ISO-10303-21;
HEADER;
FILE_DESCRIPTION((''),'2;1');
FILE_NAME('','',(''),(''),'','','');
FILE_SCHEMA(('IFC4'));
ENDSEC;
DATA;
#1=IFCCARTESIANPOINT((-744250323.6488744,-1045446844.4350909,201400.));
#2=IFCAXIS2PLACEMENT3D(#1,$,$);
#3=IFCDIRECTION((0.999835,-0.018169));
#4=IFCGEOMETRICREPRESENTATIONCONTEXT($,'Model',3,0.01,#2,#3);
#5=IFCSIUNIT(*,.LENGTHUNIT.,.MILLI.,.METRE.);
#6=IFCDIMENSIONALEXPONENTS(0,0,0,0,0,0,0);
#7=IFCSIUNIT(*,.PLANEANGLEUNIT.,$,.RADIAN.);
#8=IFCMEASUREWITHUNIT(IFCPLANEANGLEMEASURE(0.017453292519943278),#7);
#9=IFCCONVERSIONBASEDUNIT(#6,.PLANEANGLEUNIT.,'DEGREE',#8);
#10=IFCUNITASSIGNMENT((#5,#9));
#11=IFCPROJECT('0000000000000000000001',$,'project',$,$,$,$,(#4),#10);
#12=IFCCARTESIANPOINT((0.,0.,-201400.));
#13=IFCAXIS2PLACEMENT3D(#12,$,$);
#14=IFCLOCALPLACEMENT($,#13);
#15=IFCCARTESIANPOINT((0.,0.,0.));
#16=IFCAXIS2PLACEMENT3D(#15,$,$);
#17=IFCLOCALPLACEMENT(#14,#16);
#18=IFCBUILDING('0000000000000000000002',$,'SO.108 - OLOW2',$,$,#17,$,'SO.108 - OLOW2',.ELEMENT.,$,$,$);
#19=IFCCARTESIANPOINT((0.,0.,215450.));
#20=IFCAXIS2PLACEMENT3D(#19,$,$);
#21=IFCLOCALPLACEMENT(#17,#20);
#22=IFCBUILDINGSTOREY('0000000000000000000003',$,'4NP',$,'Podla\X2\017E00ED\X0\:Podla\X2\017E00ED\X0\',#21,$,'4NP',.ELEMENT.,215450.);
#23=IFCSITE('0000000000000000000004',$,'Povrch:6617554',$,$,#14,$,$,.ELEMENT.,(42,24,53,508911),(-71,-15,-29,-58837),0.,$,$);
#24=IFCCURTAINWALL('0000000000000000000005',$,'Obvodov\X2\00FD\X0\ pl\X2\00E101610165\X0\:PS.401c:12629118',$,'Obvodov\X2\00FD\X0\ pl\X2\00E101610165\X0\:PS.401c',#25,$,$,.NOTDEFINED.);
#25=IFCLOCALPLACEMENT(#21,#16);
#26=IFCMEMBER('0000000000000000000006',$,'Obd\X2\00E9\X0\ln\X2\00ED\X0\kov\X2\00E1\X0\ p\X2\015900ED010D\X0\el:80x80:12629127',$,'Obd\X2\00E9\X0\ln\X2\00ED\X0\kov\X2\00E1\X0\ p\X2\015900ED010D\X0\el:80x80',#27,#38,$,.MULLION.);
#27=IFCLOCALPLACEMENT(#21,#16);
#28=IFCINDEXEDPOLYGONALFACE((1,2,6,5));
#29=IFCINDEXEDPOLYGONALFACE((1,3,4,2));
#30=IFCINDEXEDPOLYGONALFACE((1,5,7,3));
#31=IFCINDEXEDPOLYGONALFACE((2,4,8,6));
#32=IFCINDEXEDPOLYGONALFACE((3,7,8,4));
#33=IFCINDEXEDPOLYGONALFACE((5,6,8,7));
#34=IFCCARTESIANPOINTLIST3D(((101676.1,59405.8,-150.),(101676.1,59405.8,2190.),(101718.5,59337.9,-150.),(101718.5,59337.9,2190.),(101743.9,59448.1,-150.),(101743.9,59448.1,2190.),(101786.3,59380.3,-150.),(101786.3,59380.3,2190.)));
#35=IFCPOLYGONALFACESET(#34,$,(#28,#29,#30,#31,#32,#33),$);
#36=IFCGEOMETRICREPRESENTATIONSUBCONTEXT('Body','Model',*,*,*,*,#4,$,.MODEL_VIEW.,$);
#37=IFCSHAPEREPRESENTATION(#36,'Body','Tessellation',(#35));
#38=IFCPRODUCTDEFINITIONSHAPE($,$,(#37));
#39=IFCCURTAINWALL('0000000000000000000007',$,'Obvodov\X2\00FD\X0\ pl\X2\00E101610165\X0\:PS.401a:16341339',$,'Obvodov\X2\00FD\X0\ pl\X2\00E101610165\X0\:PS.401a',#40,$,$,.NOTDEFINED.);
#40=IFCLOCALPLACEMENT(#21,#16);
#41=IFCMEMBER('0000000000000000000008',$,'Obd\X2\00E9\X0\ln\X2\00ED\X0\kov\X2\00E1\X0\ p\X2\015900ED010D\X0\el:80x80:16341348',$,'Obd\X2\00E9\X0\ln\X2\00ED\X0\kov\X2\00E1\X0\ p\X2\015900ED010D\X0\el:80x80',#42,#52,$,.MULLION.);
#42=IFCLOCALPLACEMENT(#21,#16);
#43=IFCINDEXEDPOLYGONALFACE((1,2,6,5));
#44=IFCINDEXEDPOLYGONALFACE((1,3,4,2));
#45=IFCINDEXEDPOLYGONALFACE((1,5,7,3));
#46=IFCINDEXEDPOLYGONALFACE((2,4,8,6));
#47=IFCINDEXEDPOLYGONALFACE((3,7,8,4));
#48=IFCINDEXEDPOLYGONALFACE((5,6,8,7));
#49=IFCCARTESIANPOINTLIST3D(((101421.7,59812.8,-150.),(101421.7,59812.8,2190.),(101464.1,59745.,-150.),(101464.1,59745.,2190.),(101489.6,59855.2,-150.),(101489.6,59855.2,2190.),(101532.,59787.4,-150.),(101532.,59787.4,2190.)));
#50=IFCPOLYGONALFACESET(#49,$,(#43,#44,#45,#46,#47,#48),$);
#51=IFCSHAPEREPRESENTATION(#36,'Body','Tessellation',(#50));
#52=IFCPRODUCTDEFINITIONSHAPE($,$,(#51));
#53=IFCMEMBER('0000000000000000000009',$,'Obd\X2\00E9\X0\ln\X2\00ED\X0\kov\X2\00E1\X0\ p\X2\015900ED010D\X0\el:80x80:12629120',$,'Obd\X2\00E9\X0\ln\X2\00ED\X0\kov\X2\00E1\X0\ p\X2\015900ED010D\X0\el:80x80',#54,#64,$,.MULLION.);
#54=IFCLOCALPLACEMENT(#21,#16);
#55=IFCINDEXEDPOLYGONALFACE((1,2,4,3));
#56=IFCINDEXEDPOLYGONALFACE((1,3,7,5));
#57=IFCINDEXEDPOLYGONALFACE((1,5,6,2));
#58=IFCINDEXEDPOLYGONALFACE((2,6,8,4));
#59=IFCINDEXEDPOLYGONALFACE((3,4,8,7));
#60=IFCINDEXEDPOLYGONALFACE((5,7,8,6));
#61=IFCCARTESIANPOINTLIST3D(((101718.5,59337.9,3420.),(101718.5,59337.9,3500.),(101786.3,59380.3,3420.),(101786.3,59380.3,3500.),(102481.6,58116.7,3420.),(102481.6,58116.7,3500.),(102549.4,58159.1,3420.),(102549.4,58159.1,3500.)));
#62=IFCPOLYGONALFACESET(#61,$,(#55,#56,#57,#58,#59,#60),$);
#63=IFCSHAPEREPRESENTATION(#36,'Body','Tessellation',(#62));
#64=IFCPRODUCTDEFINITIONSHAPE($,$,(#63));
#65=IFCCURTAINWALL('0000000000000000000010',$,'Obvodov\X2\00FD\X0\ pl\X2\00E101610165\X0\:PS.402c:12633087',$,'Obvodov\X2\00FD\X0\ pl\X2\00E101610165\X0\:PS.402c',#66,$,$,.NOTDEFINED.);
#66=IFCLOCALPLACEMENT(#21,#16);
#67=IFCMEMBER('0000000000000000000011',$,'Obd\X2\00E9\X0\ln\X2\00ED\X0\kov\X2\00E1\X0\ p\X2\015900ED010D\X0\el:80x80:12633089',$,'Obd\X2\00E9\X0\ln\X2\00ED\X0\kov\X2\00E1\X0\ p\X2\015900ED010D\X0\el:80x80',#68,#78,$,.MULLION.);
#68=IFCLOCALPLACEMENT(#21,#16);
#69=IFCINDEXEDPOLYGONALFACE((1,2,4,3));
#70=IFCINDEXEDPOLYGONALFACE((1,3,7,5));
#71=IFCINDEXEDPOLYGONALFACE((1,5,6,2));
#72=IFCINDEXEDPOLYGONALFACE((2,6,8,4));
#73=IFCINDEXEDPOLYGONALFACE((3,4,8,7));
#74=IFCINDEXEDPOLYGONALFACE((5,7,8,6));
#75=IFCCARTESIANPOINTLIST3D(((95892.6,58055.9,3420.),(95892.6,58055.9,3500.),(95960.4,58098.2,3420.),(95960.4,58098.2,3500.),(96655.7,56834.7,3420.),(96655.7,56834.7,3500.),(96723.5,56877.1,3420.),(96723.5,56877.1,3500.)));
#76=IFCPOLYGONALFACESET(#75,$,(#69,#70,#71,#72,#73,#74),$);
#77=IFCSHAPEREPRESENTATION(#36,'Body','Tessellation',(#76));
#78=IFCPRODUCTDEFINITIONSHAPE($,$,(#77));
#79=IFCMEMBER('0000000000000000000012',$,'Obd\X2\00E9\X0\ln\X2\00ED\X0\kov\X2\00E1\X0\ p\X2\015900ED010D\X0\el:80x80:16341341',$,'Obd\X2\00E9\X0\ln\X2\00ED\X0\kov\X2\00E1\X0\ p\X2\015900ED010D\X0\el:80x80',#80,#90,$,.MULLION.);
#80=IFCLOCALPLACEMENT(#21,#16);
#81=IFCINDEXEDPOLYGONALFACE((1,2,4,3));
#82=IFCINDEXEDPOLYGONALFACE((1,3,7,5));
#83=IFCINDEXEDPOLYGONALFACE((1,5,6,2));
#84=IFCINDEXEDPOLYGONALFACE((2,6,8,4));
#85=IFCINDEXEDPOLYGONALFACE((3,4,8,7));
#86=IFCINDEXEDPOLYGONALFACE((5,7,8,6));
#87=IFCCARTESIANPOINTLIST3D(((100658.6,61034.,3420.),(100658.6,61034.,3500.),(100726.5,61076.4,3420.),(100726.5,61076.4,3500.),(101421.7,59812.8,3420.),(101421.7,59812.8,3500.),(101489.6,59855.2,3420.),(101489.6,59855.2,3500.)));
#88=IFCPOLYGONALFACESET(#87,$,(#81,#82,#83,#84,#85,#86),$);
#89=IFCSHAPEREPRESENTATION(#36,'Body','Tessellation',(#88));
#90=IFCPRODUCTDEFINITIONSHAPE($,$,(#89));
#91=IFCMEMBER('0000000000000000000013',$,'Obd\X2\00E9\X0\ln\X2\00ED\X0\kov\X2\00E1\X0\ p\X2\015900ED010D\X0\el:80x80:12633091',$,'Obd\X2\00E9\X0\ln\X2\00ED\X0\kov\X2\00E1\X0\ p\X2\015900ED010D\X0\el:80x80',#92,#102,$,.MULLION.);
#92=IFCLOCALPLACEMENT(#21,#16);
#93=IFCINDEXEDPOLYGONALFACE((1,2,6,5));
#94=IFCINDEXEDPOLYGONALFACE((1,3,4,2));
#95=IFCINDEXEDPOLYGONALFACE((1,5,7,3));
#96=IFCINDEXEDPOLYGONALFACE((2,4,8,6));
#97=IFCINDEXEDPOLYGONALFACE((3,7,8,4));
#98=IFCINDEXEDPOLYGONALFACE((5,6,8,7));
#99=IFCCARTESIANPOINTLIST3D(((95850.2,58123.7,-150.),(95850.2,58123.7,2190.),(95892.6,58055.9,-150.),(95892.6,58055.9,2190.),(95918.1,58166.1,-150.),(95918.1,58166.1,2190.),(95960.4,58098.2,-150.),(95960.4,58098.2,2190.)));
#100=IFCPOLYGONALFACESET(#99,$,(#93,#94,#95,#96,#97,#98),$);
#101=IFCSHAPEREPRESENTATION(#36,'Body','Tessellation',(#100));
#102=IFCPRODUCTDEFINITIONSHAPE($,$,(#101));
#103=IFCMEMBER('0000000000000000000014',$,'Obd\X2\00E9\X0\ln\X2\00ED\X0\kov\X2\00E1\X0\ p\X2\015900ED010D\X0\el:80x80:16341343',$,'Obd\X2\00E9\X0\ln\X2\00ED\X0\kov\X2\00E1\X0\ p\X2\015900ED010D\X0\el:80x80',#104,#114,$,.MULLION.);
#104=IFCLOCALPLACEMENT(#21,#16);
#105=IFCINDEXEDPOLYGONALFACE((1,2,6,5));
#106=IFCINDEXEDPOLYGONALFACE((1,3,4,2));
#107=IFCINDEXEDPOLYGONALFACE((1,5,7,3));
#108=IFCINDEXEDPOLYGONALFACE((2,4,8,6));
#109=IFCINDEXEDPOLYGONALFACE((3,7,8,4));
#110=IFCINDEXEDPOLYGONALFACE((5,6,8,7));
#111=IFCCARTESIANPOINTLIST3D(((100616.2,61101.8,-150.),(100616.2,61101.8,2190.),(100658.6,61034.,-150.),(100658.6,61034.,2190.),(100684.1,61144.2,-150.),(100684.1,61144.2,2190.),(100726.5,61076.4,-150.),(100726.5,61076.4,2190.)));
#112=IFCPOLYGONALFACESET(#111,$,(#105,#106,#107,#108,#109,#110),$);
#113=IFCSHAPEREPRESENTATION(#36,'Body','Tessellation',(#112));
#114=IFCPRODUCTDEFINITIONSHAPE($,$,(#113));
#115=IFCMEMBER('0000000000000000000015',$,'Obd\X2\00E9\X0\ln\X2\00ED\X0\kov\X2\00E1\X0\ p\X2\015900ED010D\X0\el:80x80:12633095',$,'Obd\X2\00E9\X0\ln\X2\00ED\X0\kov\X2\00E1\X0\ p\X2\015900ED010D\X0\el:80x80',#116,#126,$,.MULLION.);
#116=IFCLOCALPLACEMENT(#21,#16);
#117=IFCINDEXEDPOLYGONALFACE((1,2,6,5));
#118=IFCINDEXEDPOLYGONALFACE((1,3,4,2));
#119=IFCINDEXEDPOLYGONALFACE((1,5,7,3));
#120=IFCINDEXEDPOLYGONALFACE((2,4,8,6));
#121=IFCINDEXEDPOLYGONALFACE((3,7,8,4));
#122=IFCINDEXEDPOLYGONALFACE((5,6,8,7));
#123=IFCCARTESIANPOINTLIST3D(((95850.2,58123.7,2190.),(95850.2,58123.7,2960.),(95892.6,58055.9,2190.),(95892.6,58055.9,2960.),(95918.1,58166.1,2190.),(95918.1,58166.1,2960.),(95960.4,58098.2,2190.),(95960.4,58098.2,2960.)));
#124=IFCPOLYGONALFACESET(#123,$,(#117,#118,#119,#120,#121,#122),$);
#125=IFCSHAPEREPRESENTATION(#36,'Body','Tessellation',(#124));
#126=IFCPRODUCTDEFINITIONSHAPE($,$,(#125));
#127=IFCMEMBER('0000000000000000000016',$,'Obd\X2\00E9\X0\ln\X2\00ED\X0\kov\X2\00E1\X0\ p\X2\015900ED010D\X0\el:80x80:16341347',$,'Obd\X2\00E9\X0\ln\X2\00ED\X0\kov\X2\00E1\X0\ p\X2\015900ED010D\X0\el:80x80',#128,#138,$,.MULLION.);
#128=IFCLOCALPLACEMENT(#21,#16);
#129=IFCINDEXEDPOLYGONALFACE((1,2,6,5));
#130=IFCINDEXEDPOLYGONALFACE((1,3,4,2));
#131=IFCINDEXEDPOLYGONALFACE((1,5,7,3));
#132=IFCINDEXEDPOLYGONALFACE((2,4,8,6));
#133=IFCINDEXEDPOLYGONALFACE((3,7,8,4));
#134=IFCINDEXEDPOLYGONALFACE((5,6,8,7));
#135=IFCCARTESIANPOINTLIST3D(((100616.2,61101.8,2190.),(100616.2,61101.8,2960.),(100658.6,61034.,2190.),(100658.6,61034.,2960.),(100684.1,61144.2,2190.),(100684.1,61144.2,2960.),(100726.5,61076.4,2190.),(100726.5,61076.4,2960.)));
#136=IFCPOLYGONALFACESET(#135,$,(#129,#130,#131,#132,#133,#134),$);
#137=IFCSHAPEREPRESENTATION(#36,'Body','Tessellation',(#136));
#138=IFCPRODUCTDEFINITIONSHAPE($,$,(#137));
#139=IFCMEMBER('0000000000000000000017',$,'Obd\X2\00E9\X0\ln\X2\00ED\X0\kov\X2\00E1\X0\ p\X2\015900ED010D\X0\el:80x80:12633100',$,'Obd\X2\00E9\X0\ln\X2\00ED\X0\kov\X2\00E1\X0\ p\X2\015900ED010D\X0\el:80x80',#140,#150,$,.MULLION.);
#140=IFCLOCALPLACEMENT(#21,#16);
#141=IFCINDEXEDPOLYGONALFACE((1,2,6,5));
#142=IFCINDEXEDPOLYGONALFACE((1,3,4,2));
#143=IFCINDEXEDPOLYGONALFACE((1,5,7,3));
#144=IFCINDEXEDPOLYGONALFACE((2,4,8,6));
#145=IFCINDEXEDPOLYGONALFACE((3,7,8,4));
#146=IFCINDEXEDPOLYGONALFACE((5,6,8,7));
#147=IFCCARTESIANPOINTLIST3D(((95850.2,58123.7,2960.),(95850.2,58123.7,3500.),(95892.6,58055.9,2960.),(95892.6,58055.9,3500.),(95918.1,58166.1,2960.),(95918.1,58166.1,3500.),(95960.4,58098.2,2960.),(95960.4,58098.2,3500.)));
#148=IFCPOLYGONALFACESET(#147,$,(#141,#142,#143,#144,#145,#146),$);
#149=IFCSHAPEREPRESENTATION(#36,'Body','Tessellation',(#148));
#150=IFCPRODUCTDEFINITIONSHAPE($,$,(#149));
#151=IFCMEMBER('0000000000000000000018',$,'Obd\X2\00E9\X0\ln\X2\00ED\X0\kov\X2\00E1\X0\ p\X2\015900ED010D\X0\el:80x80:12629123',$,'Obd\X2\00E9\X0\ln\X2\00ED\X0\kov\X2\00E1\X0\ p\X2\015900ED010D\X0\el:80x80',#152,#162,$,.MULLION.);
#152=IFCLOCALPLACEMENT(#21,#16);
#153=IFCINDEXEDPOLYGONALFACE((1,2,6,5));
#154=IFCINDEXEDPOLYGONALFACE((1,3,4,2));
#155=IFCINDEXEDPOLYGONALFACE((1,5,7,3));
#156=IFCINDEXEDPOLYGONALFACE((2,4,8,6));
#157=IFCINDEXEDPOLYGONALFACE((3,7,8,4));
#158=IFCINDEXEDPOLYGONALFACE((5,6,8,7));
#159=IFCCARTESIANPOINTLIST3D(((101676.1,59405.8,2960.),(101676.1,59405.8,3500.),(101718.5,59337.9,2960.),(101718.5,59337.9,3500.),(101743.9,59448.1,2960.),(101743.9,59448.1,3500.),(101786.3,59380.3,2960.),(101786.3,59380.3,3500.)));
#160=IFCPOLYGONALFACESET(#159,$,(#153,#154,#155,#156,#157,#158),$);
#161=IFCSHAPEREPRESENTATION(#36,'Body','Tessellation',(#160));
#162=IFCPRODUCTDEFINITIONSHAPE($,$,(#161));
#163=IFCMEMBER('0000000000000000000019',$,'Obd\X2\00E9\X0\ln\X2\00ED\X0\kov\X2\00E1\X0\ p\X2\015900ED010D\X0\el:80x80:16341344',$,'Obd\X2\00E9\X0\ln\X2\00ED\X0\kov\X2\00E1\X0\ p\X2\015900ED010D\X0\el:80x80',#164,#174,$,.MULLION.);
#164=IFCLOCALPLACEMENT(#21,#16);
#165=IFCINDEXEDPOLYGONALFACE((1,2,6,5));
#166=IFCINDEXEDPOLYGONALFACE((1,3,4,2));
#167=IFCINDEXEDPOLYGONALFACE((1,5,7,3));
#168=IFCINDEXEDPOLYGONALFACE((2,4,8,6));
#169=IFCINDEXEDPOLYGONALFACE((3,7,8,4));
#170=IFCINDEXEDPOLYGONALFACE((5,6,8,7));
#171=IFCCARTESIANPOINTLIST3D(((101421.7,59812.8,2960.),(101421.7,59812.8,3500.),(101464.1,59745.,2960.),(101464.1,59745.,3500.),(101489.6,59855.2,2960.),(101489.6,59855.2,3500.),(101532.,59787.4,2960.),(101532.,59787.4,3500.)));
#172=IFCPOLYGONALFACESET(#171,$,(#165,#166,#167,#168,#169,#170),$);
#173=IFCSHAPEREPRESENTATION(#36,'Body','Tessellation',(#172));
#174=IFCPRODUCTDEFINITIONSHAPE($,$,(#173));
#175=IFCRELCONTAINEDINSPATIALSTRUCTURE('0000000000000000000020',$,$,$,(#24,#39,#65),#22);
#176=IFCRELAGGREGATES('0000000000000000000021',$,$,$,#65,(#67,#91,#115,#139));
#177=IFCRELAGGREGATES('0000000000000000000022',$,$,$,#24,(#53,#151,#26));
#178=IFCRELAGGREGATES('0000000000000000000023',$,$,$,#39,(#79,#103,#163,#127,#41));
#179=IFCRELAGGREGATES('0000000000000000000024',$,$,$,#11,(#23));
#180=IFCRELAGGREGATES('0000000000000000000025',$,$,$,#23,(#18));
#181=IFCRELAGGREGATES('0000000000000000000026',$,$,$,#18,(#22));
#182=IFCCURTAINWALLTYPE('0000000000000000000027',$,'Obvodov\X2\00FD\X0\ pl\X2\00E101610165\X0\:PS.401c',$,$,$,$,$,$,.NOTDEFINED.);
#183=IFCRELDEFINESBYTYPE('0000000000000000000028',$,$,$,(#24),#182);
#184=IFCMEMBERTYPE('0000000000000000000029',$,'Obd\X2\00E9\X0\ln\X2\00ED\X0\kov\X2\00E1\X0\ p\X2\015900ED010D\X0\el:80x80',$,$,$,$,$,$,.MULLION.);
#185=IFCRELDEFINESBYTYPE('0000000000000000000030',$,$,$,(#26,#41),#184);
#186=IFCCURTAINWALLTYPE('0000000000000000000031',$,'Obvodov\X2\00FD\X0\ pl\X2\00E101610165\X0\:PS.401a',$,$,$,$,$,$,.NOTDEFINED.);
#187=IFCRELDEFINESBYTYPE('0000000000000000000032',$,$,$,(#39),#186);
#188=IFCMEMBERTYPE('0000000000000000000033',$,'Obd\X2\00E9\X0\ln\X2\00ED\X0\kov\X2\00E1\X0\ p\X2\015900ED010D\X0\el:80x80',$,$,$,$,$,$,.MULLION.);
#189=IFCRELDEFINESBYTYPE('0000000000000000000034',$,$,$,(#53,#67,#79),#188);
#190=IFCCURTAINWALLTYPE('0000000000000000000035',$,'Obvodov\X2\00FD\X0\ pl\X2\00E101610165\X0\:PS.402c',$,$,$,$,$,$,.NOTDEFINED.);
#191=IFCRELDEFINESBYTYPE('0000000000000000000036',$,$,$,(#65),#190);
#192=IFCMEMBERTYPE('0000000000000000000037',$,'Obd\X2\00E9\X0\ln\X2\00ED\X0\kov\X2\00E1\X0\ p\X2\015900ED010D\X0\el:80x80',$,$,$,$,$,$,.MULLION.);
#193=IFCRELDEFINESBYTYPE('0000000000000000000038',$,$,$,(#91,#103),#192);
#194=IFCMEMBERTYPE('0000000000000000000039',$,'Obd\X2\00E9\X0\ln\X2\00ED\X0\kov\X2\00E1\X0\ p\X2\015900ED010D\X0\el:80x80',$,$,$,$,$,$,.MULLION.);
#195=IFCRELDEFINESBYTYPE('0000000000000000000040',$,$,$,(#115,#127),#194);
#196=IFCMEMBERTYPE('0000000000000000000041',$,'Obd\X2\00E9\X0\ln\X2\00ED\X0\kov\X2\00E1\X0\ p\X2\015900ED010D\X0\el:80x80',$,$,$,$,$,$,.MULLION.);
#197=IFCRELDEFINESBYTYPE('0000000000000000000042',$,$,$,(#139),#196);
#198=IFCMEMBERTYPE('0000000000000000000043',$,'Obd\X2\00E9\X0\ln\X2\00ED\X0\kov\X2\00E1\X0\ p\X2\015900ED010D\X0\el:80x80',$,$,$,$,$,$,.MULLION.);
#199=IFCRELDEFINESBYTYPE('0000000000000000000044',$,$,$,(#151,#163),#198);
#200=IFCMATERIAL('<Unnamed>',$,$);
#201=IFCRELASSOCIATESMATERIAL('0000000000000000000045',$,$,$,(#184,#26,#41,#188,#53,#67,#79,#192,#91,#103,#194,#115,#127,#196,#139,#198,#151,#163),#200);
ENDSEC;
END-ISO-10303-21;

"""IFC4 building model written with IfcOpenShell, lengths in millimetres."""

from ifc_helpers import new_model, entity, si_unit, converted_unit, direction, frame, origin, place, context, subcontext, project, spatial, indexed_curve, outline, extrude, source, transform, mapped, material, type_object, type_shapes, element, aggregate, save


model = new_model("IFC4")

# Units and contexts
model_context = context("Model", 3, precision=0.01, world=frame((-744250323.6488744, -1045446844.4350909, 201400.0)), true_north=direction((0.999835, -0.018169)))
body_context = subcontext(model_context, "Body", "Model", "MODEL_VIEW")
ifc_project = project(units=[si_unit("LENGTHUNIT", "METRE", prefix="MILLI"), converted_unit("PLANEANGLEUNIT", "DEGREE", entity("IfcPlaneAngleMeasure", 0.017453292519943278), si_unit("PLANEANGLEUNIT", "RADIAN"), dimensions=[0, 0, 0, 0, 0, 0, 0])], contexts=[model_context])

# Site, building, storey
site_placement = place(None, frame((0.0, 0.0, -201400.0)))
site = spatial("IfcSite", under=ifc_project, at=site_placement, Name="Povrch:6617554", CompositionType="ELEMENT", RefLatitude=(42, 24, 53, 508911), RefLongitude=(-71, -15, -29, -58837), RefElevation=0.0)
building_placement = place(site_placement, origin())
building = spatial("IfcBuilding", under=site, at=building_placement, Name="SO.108 - OLOW2", LongName="SO.108 - OLOW2", CompositionType="ELEMENT")
storey_placement = place(building_placement, frame((0.0, 0.0, 215450.0)))
storey = spatial("IfcBuildingStorey", under=building, at=storey_placement, Name="4NP", ObjectType="Podlaží:Podlaží", LongName="4NP", CompositionType="ELEMENT", Elevation=215450.0)

# Curtain walls, members
curtain_wall_type_1 = type_object("IfcCurtainWallType", Name="Obvodový plášť:PS.401c", PredefinedType="NOTDEFINED")
curtain_wall_1_placement = place(storey_placement, frame((0.0, 0.0, -215450.0)))
curtain_wall_1 = element("IfcCurtainWall", 1, at=curtain_wall_1_placement, inside=storey, type_object=curtain_wall_type_1, Name="Obvodový plášť:PS.401c:12629118", ObjectType="Obvodový plášť:PS.401c", PredefinedType="NOTDEFINED")
ifc_material_1 = material(Name="<Unnamed>")
member_type_1 = type_object("IfcMemberType", Name="Obdélníková příčel:80x80", PredefinedType="MULLION", material=ifc_material_1)
shared_shape_1 = source(origin(), body_context, "Body", "SweptSolid", [
    extrude(outline(indexed_curve([(-40.0, -40.0), (40.0, -40.0), (40.0, 40.0), (-40.0, 40.0), (-40.0, -40.0)], self_intersect=False)), frame((-40.0, 0.0, -2340.0), z_axis=(0.0, 0.0, 1.0), x_axis=(-1.0, 0.0, 0.0)), (0.0, 0.0, 1.0), 2340.0),
])
type_shapes(member_type_1, [shared_shape_1])
member_1_placement = place(curtain_wall_1_placement, frame((101710.0, 59426.9, 217640.0), z_axis=(0.0, 0.0, 1.0), x_axis=(-0.529919, 0.848048, 0.0)))
member_1 = element("IfcMember", 2, at=member_1_placement, type_object=member_type_1, material=ifc_material_1, Name="Obdélníková příčel:80x80:12629127", ObjectType="Obdélníková příčel:80x80", PredefinedType="MULLION", context=body_context, shape_type="MappedRepresentation", body=[
    mapped(shared_shape_1, transform((0.0, 0.0, 0.0), scale=1.0)),
])
curtain_wall_type_2 = type_object("IfcCurtainWallType", Name="Obvodový plášť:PS.401a", PredefinedType="NOTDEFINED")
curtain_wall_2_placement = place(storey_placement, frame((0.0, 0.0, -215450.0)))
curtain_wall_2 = element("IfcCurtainWall", 3, at=curtain_wall_2_placement, inside=storey, type_object=curtain_wall_type_2, Name="Obvodový plášť:PS.401a:16341339", ObjectType="Obvodový plášť:PS.401a", PredefinedType="NOTDEFINED")
member_2_placement = place(curtain_wall_2_placement, frame((101498.0, 59766.2, 217640.0), z_axis=(0.0, 0.0, 1.0), x_axis=(0.529919, -0.848048, 0.0)))
member_2 = element("IfcMember", 4, at=member_2_placement, type_object=member_type_1, material=ifc_material_1, Name="Obdélníková příčel:80x80:16341348", ObjectType="Obdélníková příčel:80x80", PredefinedType="MULLION", context=body_context, shape_type="MappedRepresentation", body=[
    mapped(shared_shape_1, transform((0.0, 0.0, 0.0), scale=1.0)),
])

# Member
member_type_2 = type_object("IfcMemberType", Name="Obdélníková příčel:80x80", PredefinedType="MULLION", material=ifc_material_1)
shared_shape_2 = source(origin(), body_context, "Body", "SweptSolid", [
    extrude(outline(indexed_curve([(-40.0, -40.0), (40.0, -40.0), (40.0, 40.0), (-40.0, 40.0), (-40.0, -40.0)], self_intersect=False)), frame((-40.0, 0.0, -1440.0), z_axis=(0.0, 0.0, 1.0), x_axis=(-1.0, 0.0, 0.0)), (0.0, 0.0, 1.0), 1440.0),
])
type_shapes(member_type_2, [shared_shape_2])
member_3_placement = place(curtain_wall_1_placement, frame((102515.5, 58137.9, 218950.0), z_axis=(0.529919, -0.848048, 0.0), x_axis=(0.0, 0.0, 1.0)))
member_3 = element("IfcMember", 5, at=member_3_placement, type_object=member_type_2, material=ifc_material_1, Name="Obdélníková příčel:80x80:12629120", ObjectType="Obdélníková příčel:80x80", PredefinedType="MULLION", context=body_context, shape_type="MappedRepresentation", body=[
    mapped(shared_shape_2, transform((0.0, 0.0, 0.0), scale=1.0)),
])

# Curtain wall, member
curtain_wall_type_3 = type_object("IfcCurtainWallType", Name="Obvodový plášť:PS.402c", PredefinedType="NOTDEFINED")
curtain_wall_3_placement = place(storey_placement, frame((0.0, 0.0, -215450.0)))
curtain_wall_3 = element("IfcCurtainWall", 6, at=curtain_wall_3_placement, inside=storey, type_object=curtain_wall_type_3, Name="Obvodový plášť:PS.402c:12633087", ObjectType="Obvodový plášť:PS.402c", PredefinedType="NOTDEFINED")
member_4_placement = place(curtain_wall_3_placement, frame((95926.5, 58077.0, 218950.0), z_axis=(-0.529919, 0.848048, 0.0), x_axis=(0.0, 0.0, 1.0)))
member_4 = element("IfcMember", 7, at=member_4_placement, type_object=member_type_2, material=ifc_material_1, Name="Obdélníková příčel:80x80:12633089", ObjectType="Obdélníková příčel:80x80", PredefinedType="MULLION", context=body_context, shape_type="MappedRepresentation", body=[
    mapped(shared_shape_2, transform((0.0, 0.0, 0.0), scale=1.0)),
])

# Members
member_5_placement = place(curtain_wall_2_placement, frame((100692.6, 61055.2, 218950.0), z_axis=(-0.529919, 0.848048, 0.0), x_axis=(0.0, 0.0, 1.0)))
member_5 = element("IfcMember", 8, at=member_5_placement, type_object=member_type_2, material=ifc_material_1, Name="Obdélníková příčel:80x80:16341341", ObjectType="Obdélníková příčel:80x80", PredefinedType="MULLION", context=body_context, shape_type="MappedRepresentation", body=[
    mapped(shared_shape_2, transform((0.0, 0.0, 0.0), scale=1.0)),
])
member_type_3 = type_object("IfcMemberType", Name="Obdélníková příčel:80x80", PredefinedType="MULLION", material=ifc_material_1)
shared_shape_3 = source(origin(), body_context, "Body", "SweptSolid", [
    extrude(outline(indexed_curve([(-40.0, -40.0), (40.0, -40.0), (40.0, 40.0), (-40.0, 40.0), (-40.0, -40.0)], self_intersect=False)), frame((-40.0, 0.0, -2340.0), z_axis=(0.0, 0.0, 1.0), x_axis=(-1.0, 0.0, 0.0)), (0.0, 0.0, 1.0), 2340.0),
])
type_shapes(member_type_3, [shared_shape_3])
member_6_placement = place(curtain_wall_3_placement, frame((95884.1, 58144.9, 215300.0), z_axis=(0.0, 0.0, -1.0), x_axis=(-0.529919, 0.848048, 0.0)))
member_6 = element("IfcMember", 9, at=member_6_placement, type_object=member_type_3, material=ifc_material_1, Name="Obdélníková příčel:80x80:12633091", ObjectType="Obdélníková příčel:80x80", PredefinedType="MULLION", context=body_context, shape_type="MappedRepresentation", body=[
    mapped(shared_shape_3, transform((0.0, 0.0, 0.0), scale=1.0)),
])
member_7_placement = place(curtain_wall_2_placement, frame((100650.2, 61123.0, 215300.0), z_axis=(0.0, 0.0, -1.0), x_axis=(-0.529919, 0.848048, 0.0)))
member_7 = element("IfcMember", 10, at=member_7_placement, type_object=member_type_3, material=ifc_material_1, Name="Obdélníková příčel:80x80:16341343", ObjectType="Obdélníková příčel:80x80", PredefinedType="MULLION", context=body_context, shape_type="MappedRepresentation", body=[
    mapped(shared_shape_3, transform((0.0, 0.0, 0.0), scale=1.0)),
])
member_type_4 = type_object("IfcMemberType", Name="Obdélníková příčel:80x80", PredefinedType="MULLION", material=ifc_material_1)
shared_shape_4 = source(origin(), body_context, "Body", "SweptSolid", [
    extrude(outline(indexed_curve([(-40.0, -40.0), (40.0, -40.0), (40.0, 40.0), (-40.0, 40.0), (-40.0, -40.0)], self_intersect=False)), frame((-40.0, 0.0, -770.0), z_axis=(0.0, 0.0, 1.0), x_axis=(-1.0, 0.0, 0.0)), (0.0, 0.0, 1.0), 770.0),
])
type_shapes(member_type_4, [shared_shape_4])
member_8_placement = place(curtain_wall_3_placement, frame((95884.1, 58144.9, 217640.0), z_axis=(0.0, 0.0, -1.0), x_axis=(-0.529919, 0.848048, 0.0)))
member_8 = element("IfcMember", 11, at=member_8_placement, type_object=member_type_4, material=ifc_material_1, Name="Obdélníková příčel:80x80:12633095", ObjectType="Obdélníková příčel:80x80", PredefinedType="MULLION", context=body_context, shape_type="MappedRepresentation", body=[
    mapped(shared_shape_4, transform((0.0, 0.0, 0.0), scale=1.0)),
])
member_9_placement = place(curtain_wall_2_placement, frame((100650.2, 61123.0, 217640.0), z_axis=(0.0, 0.0, -1.0), x_axis=(-0.529919, 0.848048, 0.0)))
member_9 = element("IfcMember", 12, at=member_9_placement, type_object=member_type_4, material=ifc_material_1, Name="Obdélníková příčel:80x80:16341347", ObjectType="Obdélníková příčel:80x80", PredefinedType="MULLION", context=body_context, shape_type="MappedRepresentation", body=[
    mapped(shared_shape_4, transform((0.0, 0.0, 0.0), scale=1.0)),
])
member_type_5 = type_object("IfcMemberType", Name="Obdélníková příčel:80x80", PredefinedType="MULLION", material=ifc_material_1)
shared_shape_5 = source(origin(), body_context, "Body", "SweptSolid", [
    extrude(outline(indexed_curve([(-40.0, -40.0), (40.0, -40.0), (40.0, 40.0), (-40.0, 40.0), (-40.0, -40.0)], self_intersect=False)), frame((-40.0, 0.0, -540.0), z_axis=(0.0, 0.0, 1.0), x_axis=(-1.0, 0.0, 0.0)), (0.0, 0.0, 1.0), 540.0),
])
type_shapes(member_type_5, [shared_shape_5])
member_10_placement = place(curtain_wall_3_placement, frame((95884.1, 58144.9, 218410.0), z_axis=(0.0, 0.0, -1.0), x_axis=(-0.529919, 0.848048, 0.0)))
member_10 = element("IfcMember", 13, at=member_10_placement, type_object=member_type_5, material=ifc_material_1, Name="Obdélníková příčel:80x80:12633100", ObjectType="Obdélníková příčel:80x80", PredefinedType="MULLION", context=body_context, shape_type="MappedRepresentation", body=[
    mapped(shared_shape_5, transform((0.0, 0.0, 0.0), scale=1.0)),
])
member_type_6 = type_object("IfcMemberType", Name="Obdélníková příčel:80x80", PredefinedType="MULLION", material=ifc_material_1)
shared_shape_6 = source(origin(), body_context, "Body", "SweptSolid", [
    extrude(outline(indexed_curve([(-40.0, -40.0), (40.0, -40.0), (40.0, 40.0), (-40.0, 40.0), (-40.0, -40.0)], self_intersect=False)), frame((-40.0, 0.0, -540.0), z_axis=(0.0, 0.0, 1.0), x_axis=(-1.0, 0.0, 0.0)), (0.0, 0.0, 1.0), 540.0),
])
type_shapes(member_type_6, [shared_shape_6])
member_11_placement = place(curtain_wall_1_placement, frame((101710.0, 59426.9, 218950.0), z_axis=(0.0, 0.0, 1.0), x_axis=(-0.529919, 0.848048, 0.0)))
member_11 = element("IfcMember", 14, at=member_11_placement, type_object=member_type_6, material=ifc_material_1, Name="Obdélníková příčel:80x80:12629123", ObjectType="Obdélníková příčel:80x80", PredefinedType="MULLION", context=body_context, shape_type="MappedRepresentation", body=[
    mapped(shared_shape_6, transform((0.0, 0.0, 0.0), scale=1.0)),
])
member_12_placement = place(curtain_wall_2_placement, frame((101498.0, 59766.2, 218950.0), z_axis=(0.0, 0.0, 1.0), x_axis=(0.529919, -0.848048, 0.0)))
member_12 = element("IfcMember", 15, at=member_12_placement, type_object=member_type_6, material=ifc_material_1, Name="Obdélníková příčel:80x80:16341344", ObjectType="Obdélníková příčel:80x80", PredefinedType="MULLION", context=body_context, shape_type="MappedRepresentation", body=[
    mapped(shared_shape_6, transform((0.0, 0.0, 0.0), scale=1.0)),
])
aggregate(curtain_wall_3, [member_4, member_6, member_8, member_10])

aggregate(curtain_wall_1, [member_3, member_11, member_1])

aggregate(curtain_wall_2, [member_5, member_7, member_12, member_9, member_2])

save(model, "model.ifc")
